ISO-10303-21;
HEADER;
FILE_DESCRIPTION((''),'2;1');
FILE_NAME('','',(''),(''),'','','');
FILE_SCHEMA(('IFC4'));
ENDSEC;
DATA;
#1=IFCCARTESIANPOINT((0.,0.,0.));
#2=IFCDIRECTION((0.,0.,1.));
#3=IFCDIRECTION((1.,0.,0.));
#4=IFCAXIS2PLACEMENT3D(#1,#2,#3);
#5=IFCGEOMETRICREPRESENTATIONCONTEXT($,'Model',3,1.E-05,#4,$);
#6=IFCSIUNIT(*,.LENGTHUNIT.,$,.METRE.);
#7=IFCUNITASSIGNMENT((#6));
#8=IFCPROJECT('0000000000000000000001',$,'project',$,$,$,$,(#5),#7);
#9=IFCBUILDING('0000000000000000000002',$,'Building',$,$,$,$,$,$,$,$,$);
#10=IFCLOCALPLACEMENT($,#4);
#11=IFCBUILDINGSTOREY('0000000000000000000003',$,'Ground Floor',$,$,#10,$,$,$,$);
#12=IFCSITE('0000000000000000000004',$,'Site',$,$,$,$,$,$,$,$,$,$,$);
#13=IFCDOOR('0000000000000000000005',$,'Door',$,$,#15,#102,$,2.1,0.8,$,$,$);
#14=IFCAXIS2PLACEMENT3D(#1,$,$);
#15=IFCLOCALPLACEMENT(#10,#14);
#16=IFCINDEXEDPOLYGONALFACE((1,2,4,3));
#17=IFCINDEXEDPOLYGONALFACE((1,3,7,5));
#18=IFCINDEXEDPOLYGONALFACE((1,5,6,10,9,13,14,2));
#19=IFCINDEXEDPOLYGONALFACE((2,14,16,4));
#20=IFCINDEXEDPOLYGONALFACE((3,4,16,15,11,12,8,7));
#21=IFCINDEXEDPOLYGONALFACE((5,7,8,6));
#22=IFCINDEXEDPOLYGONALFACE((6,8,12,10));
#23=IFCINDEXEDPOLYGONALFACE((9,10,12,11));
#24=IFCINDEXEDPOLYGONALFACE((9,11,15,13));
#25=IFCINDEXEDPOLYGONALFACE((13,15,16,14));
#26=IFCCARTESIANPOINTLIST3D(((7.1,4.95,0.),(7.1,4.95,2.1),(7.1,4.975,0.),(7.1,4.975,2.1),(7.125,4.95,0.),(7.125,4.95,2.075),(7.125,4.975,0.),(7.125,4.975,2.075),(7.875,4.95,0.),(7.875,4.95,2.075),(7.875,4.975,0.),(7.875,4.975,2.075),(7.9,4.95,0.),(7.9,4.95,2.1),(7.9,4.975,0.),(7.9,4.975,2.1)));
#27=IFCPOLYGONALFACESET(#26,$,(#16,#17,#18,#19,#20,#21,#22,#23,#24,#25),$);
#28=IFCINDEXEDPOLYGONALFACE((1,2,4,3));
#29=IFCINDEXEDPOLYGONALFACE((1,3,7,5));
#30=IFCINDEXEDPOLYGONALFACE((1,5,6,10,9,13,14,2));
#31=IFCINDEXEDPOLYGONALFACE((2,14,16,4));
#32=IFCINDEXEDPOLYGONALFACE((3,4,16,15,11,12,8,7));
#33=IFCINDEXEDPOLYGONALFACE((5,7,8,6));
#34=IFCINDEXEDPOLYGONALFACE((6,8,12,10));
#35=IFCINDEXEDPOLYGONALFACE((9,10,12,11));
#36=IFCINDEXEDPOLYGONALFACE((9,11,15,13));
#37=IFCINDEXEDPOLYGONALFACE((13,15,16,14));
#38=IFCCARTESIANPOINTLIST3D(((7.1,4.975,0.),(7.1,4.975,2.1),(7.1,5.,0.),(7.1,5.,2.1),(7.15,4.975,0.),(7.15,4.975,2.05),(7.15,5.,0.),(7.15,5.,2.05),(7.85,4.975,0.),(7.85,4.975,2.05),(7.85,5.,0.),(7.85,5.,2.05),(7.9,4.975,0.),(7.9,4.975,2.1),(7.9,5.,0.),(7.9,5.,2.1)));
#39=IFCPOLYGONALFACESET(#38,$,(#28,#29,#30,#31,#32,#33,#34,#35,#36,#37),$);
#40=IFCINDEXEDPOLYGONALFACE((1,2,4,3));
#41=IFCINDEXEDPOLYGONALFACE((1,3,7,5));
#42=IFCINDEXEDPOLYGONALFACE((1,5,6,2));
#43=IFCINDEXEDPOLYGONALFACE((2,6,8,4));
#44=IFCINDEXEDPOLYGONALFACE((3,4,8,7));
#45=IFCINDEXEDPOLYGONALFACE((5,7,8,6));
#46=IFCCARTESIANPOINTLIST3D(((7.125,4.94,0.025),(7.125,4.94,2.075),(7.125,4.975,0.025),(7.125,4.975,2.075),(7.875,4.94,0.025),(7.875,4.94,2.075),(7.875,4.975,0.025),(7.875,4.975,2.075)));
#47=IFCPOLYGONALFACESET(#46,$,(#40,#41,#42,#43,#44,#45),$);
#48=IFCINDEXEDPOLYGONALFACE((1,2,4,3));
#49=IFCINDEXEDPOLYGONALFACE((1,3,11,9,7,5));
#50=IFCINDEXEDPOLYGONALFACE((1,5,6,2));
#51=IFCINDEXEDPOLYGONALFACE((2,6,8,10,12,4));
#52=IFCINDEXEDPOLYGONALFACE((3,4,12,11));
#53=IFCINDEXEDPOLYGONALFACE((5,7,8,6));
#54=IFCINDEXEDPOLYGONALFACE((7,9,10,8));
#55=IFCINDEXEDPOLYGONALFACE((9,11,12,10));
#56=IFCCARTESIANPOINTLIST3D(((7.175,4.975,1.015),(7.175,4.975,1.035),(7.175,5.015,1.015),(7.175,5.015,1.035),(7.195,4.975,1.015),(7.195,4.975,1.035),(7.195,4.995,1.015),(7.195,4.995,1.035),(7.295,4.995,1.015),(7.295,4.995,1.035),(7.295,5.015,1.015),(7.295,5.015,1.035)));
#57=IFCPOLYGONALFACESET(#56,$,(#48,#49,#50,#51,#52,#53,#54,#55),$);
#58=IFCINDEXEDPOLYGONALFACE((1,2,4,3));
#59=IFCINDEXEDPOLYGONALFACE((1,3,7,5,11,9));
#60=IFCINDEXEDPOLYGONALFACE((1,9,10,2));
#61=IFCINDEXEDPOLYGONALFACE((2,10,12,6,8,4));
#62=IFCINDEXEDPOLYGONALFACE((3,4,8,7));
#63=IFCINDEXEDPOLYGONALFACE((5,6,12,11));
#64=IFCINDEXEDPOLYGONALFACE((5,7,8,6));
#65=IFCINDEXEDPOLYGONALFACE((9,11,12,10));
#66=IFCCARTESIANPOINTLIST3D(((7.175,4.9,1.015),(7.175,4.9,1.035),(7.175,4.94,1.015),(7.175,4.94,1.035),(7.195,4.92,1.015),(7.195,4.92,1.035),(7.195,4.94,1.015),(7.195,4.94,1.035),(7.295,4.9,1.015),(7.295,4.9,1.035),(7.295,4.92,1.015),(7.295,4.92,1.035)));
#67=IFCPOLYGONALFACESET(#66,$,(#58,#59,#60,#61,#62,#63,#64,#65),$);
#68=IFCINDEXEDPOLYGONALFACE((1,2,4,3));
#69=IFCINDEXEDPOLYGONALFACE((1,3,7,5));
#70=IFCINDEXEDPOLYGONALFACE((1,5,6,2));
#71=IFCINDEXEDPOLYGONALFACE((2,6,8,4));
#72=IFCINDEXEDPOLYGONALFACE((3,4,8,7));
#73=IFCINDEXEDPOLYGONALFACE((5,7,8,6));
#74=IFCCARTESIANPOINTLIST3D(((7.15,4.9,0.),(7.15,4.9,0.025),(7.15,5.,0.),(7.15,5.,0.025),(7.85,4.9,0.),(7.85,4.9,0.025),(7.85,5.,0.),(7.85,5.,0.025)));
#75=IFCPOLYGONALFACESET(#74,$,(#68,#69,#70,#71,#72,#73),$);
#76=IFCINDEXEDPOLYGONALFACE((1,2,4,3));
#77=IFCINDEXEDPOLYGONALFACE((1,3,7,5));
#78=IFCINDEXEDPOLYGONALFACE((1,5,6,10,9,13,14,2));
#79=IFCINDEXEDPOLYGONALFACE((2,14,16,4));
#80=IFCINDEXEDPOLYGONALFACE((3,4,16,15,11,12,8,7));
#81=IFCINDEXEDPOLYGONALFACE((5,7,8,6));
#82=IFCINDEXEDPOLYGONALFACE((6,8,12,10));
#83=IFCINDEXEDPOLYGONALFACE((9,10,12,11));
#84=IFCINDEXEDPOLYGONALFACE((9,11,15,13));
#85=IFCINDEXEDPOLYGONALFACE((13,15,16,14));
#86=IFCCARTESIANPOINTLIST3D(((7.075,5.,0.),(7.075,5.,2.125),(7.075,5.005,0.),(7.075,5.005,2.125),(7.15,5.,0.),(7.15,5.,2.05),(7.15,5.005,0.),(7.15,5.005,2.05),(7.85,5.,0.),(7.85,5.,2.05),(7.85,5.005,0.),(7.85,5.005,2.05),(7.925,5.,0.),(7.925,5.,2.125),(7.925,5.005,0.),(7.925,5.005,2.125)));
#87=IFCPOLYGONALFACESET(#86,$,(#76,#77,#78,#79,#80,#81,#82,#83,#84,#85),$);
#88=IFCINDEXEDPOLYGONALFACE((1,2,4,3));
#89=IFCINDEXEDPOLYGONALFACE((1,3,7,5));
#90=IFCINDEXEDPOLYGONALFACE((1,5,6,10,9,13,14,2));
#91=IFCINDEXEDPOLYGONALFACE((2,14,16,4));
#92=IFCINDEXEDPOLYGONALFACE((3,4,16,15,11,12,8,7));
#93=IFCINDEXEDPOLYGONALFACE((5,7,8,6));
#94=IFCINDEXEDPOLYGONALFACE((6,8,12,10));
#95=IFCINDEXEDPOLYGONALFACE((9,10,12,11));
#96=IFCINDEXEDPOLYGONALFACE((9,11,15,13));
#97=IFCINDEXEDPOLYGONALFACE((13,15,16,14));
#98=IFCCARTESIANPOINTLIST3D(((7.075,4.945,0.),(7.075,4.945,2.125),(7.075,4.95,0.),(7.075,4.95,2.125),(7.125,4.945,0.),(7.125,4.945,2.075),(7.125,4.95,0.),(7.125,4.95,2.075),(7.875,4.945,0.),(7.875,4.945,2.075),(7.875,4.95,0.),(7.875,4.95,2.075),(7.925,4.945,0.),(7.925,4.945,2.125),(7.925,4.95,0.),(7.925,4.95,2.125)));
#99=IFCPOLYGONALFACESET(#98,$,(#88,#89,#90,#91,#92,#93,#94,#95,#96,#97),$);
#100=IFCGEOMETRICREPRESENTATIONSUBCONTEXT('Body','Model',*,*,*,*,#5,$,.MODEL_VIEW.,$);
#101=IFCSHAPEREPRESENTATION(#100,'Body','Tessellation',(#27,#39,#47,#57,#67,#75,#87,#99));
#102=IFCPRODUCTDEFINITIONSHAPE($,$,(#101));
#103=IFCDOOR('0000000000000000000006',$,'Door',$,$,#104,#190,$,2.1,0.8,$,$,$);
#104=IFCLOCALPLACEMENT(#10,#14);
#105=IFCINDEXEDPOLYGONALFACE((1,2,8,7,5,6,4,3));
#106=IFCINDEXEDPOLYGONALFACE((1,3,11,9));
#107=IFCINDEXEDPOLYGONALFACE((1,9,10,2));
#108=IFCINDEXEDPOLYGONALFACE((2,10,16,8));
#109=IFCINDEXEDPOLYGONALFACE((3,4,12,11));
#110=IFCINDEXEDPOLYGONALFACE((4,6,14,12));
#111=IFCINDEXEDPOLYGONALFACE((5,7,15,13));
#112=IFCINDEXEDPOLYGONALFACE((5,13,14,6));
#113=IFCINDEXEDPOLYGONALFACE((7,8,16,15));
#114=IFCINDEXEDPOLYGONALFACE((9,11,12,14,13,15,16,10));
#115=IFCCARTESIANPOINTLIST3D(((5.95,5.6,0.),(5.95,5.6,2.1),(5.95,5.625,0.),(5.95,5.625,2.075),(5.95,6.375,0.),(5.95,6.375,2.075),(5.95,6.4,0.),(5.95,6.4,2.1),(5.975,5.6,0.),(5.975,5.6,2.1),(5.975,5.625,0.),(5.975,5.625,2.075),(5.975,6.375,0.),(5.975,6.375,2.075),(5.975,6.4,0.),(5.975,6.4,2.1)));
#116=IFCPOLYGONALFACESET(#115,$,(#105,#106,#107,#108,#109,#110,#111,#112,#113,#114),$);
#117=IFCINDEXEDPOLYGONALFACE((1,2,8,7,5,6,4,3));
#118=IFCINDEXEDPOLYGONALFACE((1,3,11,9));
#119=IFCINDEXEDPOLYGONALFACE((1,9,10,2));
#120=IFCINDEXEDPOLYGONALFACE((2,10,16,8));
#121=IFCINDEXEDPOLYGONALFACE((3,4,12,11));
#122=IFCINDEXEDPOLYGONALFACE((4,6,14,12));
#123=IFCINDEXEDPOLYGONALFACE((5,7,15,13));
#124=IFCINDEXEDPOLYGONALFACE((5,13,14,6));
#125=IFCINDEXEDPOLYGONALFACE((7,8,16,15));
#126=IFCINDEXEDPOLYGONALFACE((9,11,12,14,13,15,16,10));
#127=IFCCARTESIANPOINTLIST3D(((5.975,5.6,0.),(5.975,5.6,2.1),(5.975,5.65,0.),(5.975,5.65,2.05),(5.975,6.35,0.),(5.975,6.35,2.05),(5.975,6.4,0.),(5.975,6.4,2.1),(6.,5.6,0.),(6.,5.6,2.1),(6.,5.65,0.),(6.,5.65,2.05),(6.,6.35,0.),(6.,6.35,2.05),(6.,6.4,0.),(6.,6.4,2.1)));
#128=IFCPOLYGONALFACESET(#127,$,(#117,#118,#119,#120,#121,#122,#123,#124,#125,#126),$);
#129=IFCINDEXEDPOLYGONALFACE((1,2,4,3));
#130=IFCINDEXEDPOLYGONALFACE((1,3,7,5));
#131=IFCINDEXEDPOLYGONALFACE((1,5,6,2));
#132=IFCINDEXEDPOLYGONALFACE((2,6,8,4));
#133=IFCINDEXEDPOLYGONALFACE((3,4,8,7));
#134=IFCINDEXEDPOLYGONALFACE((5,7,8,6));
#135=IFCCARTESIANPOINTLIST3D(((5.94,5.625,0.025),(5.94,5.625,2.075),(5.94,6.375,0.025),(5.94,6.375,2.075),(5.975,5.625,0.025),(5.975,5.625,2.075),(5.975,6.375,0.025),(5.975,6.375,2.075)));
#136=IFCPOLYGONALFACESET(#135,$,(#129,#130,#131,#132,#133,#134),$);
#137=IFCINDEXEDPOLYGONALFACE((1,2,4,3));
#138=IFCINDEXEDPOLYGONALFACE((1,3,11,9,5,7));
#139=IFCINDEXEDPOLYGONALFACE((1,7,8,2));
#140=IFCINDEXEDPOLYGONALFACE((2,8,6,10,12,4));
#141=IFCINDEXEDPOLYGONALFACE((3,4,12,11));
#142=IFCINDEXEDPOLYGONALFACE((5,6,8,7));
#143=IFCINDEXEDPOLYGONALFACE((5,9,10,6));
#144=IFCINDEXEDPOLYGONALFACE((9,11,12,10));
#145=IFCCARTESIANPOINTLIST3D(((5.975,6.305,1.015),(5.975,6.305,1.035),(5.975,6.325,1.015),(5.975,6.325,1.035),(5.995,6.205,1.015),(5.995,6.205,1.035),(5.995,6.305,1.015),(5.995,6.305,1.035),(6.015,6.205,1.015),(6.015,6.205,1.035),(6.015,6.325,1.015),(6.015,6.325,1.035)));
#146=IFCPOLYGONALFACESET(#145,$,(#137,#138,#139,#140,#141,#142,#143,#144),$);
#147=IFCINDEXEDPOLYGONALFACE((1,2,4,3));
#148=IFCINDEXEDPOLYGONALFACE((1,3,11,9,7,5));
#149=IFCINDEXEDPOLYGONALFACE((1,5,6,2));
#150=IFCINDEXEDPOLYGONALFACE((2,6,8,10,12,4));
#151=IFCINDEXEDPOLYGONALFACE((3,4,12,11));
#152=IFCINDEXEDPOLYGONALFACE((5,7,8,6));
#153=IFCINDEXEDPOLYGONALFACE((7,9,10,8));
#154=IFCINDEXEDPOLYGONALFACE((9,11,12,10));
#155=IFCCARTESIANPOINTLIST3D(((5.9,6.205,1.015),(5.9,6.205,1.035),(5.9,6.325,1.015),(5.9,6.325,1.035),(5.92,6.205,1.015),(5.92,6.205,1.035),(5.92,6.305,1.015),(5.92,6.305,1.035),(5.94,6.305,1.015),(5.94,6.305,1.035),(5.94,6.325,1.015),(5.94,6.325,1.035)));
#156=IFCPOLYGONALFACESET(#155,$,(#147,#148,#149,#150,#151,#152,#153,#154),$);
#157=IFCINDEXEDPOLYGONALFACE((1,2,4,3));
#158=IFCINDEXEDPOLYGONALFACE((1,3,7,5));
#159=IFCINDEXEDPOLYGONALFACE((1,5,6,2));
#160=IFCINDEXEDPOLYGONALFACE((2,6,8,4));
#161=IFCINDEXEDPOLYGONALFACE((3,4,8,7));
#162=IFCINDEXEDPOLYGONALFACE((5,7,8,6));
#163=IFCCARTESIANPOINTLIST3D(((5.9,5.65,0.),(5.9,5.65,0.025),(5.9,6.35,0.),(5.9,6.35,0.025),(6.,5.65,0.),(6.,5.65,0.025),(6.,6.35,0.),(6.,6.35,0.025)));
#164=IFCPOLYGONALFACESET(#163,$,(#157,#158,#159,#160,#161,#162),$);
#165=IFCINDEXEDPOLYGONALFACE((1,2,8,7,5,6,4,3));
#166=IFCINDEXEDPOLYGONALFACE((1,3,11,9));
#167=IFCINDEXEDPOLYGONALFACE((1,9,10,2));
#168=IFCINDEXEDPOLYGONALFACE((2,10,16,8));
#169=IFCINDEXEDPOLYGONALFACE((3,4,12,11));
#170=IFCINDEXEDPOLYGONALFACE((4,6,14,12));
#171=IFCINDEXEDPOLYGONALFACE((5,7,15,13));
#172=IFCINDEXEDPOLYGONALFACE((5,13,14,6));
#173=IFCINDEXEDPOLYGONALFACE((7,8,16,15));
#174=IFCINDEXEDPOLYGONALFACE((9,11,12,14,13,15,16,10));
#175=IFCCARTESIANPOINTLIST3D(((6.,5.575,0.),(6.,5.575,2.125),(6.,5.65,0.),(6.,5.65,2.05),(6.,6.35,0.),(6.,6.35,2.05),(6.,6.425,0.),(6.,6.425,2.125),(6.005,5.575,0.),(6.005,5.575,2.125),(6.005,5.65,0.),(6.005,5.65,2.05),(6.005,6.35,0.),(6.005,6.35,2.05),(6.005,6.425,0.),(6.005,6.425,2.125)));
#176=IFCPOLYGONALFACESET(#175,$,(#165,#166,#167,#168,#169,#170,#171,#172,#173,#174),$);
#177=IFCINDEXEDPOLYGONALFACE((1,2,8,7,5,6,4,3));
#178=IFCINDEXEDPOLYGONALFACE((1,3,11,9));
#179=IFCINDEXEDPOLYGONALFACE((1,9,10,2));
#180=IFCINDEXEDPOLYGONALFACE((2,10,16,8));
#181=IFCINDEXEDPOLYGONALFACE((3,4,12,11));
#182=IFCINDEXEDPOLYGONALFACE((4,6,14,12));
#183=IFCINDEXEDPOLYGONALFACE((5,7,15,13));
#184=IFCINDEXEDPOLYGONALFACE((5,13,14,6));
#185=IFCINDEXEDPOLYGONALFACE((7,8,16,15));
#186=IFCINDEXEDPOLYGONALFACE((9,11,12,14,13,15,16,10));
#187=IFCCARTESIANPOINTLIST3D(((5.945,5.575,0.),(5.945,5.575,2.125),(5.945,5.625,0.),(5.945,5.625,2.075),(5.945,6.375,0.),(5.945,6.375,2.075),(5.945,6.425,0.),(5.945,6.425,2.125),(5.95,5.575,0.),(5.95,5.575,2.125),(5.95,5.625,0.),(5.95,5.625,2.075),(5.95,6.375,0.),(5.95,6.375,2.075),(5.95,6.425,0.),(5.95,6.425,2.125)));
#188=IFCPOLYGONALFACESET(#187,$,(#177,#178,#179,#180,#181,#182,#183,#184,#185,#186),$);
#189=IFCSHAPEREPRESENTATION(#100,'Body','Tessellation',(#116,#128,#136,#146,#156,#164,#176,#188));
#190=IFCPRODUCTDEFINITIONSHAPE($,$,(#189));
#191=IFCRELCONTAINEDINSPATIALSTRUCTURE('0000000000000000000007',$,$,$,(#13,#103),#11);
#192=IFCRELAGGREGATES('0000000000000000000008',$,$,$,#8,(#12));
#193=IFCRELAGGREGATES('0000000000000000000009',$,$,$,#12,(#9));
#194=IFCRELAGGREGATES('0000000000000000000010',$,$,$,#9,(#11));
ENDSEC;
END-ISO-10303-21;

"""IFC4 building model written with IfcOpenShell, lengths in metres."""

from ifc_helpers import new_model, si_unit, frame, origin_with_axes, place, context, subcontext, project, spatial, line, indexed_curve, outline, extrude, element, save


model = new_model("IFC4")

# Units and contexts
model_context = context("Model", 3, precision=1e-05, world=origin_with_axes())
body_context = subcontext(model_context, "Body", "Model", "MODEL_VIEW")
ifc_project = project(units=[si_unit("LENGTHUNIT", "METRE")], contexts=[model_context])

# Site, building, storey
site = spatial("IfcSite", under=ifc_project, Name="Site")
building = spatial("IfcBuilding", under=site, Name="Building")
storey_placement = place(None, origin_with_axes())
storey = spatial("IfcBuildingStorey", under=building, at=storey_placement, Name="Ground Floor")

# Doors
door_1_placement = place(storey_placement, frame((7.9, 5.0, 0.0), z_axis=(0.0, 0.0, 1.0), x_axis=(-1.0, 0.0, 0.0)))
element("IfcDoor", 1, at=door_1_placement, inside=storey, Name="Door", OverallHeight=2.1, OverallWidth=0.8, context=body_context, shape_type="SweptSolid", body=[
    extrude(outline(indexed_curve([(0.0, 0.0), (0.0, 2.1), (0.8, 2.1), (0.8, 0.0), (0.775, 0.0), (0.775, 2.075), (0.025, 2.075), (0.025, 0.0)], segments=[line(1, 2, 3, 4, 5, 6, 7, 8, 1)])), frame((0.0, 0.025, 0.0), z_axis=(0.0, -1.0, 0.0), x_axis=(1.0, 0.0, 0.0)), (0.0, 0.0, -1.0), 0.025),
    extrude(outline(indexed_curve([(0.0, 0.0), (0.0, 2.1), (0.8, 2.1), (0.8, 0.0), (0.75, 0.0), (0.75, 2.05), (0.05, 2.05), (0.05, 0.0)], segments=[line(1, 2, 3, 4, 5, 6, 7, 8, 1)])), frame((0.0, 0.0, 0.0), z_axis=(0.0, -1.0, 0.0), x_axis=(1.0, 0.0, 0.0)), (0.0, 0.0, -1.0), 0.025),
    extrude(outline(indexed_curve([(0.0, 0.0), (0.75, 0.0), (0.75, 0.035), (0.0, 0.035)], segments=[line(1, 2, 3, 4, 1)])), frame((0.025, 0.025, 0.025), z_axis=(0.0, 0.0, 1.0), x_axis=(1.0, 0.0, 0.0)), (0.0, 0.0, 1.0), 2.05),
    extrude(outline(indexed_curve([(0.0, 0.0), (0.0, -0.04), (-0.12, -0.04), (-0.12, -0.02), (-0.02, -0.02), (-0.02, 0.0)], segments=[line(1, 2, 3, 4, 5, 6, 1)])), frame((0.725, 0.025, 1.015), z_axis=(0.0, 0.0, 1.0), x_axis=(1.0, 0.0, 0.0)), (0.0, 0.0, 1.0), 0.02),
    extrude(outline(indexed_curve([(0.0, 0.0), (0.0, 0.04), (-0.12, 0.04), (-0.12, 0.02), (-0.02, 0.02), (-0.02, 0.0)], segments=[line(1, 2, 3, 4, 5, 6, 1)])), frame((0.725, 0.06, 1.015), z_axis=(0.0, 0.0, 1.0), x_axis=(1.0, 0.0, 0.0)), (0.0, 0.0, 1.0), 0.02),
    extrude(outline(indexed_curve([(0.0, 0.0), (0.7, 0.0), (0.7, 0.1), (0.0, 0.1)], segments=[line(1, 2, 3, 4, 1)])), frame((0.05, 0.0, 0.0), z_axis=(0.0, 0.0, 1.0), x_axis=(1.0, 0.0, 0.0)), (0.0, 0.0, 1.0), 0.025),
    extrude(outline(indexed_curve([(0.0, 0.0), (0.0, 2.125), (0.85, 2.125), (0.85, 0.0), (0.775, 0.0), (0.775, 2.05), (0.075, 2.05), (0.075, 0.0)], segments=[line(1, 2, 3, 4, 5, 6, 7, 8, 1)])), frame((-0.025, -0.005, 0.0), z_axis=(0.0, -1.0, 0.0), x_axis=(1.0, 0.0, 0.0)), (0.0, 0.0, -1.0), 0.005),
    extrude(outline(indexed_curve([(0.0, 0.0), (0.0, 2.125), (0.85, 2.125), (0.85, 0.0), (0.8, 0.0), (0.8, 2.075), (0.05, 2.075), (0.05, 0.0)], segments=[line(1, 2, 3, 4, 5, 6, 7, 8, 1)])), frame((-0.025, 0.05, 0.0), z_axis=(0.0, -1.0, 0.0), x_axis=(1.0, 0.0, 0.0)), (0.0, 0.0, -1.0), 0.005),
])
door_2_placement = place(storey_placement, frame((6.0, 5.6, 0.0), z_axis=(0.0, 0.0, 1.0), x_axis=(0.0, 1.0, 0.0)))
element("IfcDoor", 2, at=door_2_placement, inside=storey, Name="Door", OverallHeight=2.1, OverallWidth=0.8, context=body_context, shape_type="SweptSolid", body=[
    extrude(outline(indexed_curve([(0.0, 0.0), (0.0, 2.1), (0.8, 2.1), (0.8, 0.0), (0.775, 0.0), (0.775, 2.075), (0.025, 2.075), (0.025, 0.0)], segments=[line(1, 2, 3, 4, 5, 6, 7, 8, 1)])), frame((0.0, 0.025, 0.0), z_axis=(0.0, -1.0, 0.0), x_axis=(1.0, 0.0, 0.0)), (0.0, 0.0, -1.0), 0.025),
    extrude(outline(indexed_curve([(0.0, 0.0), (0.0, 2.1), (0.8, 2.1), (0.8, 0.0), (0.75, 0.0), (0.75, 2.05), (0.05, 2.05), (0.05, 0.0)], segments=[line(1, 2, 3, 4, 5, 6, 7, 8, 1)])), frame((0.0, 0.0, 0.0), z_axis=(0.0, -1.0, 0.0), x_axis=(1.0, 0.0, 0.0)), (0.0, 0.0, -1.0), 0.025),
    extrude(outline(indexed_curve([(0.0, 0.0), (0.75, 0.0), (0.75, 0.035), (0.0, 0.035)], segments=[line(1, 2, 3, 4, 1)])), frame((0.025, 0.025, 0.025), z_axis=(0.0, 0.0, 1.0), x_axis=(1.0, 0.0, 0.0)), (0.0, 0.0, 1.0), 2.05),
    extrude(outline(indexed_curve([(0.0, 0.0), (0.0, -0.04), (-0.12, -0.04), (-0.12, -0.02), (-0.02, -0.02), (-0.02, 0.0)], segments=[line(1, 2, 3, 4, 5, 6, 1)])), frame((0.725, 0.025, 1.015), z_axis=(0.0, 0.0, 1.0), x_axis=(1.0, 0.0, 0.0)), (0.0, 0.0, 1.0), 0.02),
    extrude(outline(indexed_curve([(0.0, 0.0), (0.0, 0.04), (-0.12, 0.04), (-0.12, 0.02), (-0.02, 0.02), (-0.02, 0.0)], segments=[line(1, 2, 3, 4, 5, 6, 1)])), frame((0.725, 0.06, 1.015), z_axis=(0.0, 0.0, 1.0), x_axis=(1.0, 0.0, 0.0)), (0.0, 0.0, 1.0), 0.02),
    extrude(outline(indexed_curve([(0.0, 0.0), (0.7, 0.0), (0.7, 0.1), (0.0, 0.1)], segments=[line(1, 2, 3, 4, 1)])), frame((0.05, 0.0, 0.0), z_axis=(0.0, 0.0, 1.0), x_axis=(1.0, 0.0, 0.0)), (0.0, 0.0, 1.0), 0.025),
    extrude(outline(indexed_curve([(0.0, 0.0), (0.0, 2.125), (0.85, 2.125), (0.85, 0.0), (0.775, 0.0), (0.775, 2.05), (0.075, 2.05), (0.075, 0.0)], segments=[line(1, 2, 3, 4, 5, 6, 7, 8, 1)])), frame((-0.025, -0.005, 0.0), z_axis=(0.0, -1.0, 0.0), x_axis=(1.0, 0.0, 0.0)), (0.0, 0.0, -1.0), 0.005),
    extrude(outline(indexed_curve([(0.0, 0.0), (0.0, 2.125), (0.85, 2.125), (0.85, 0.0), (0.8, 0.0), (0.8, 2.075), (0.05, 2.075), (0.05, 0.0)], segments=[line(1, 2, 3, 4, 5, 6, 7, 8, 1)])), frame((-0.025, 0.05, 0.0), z_axis=(0.0, -1.0, 0.0), x_axis=(1.0, 0.0, 0.0)), (0.0, 0.0, -1.0), 0.005),
])

save(model, "model.ifc")
